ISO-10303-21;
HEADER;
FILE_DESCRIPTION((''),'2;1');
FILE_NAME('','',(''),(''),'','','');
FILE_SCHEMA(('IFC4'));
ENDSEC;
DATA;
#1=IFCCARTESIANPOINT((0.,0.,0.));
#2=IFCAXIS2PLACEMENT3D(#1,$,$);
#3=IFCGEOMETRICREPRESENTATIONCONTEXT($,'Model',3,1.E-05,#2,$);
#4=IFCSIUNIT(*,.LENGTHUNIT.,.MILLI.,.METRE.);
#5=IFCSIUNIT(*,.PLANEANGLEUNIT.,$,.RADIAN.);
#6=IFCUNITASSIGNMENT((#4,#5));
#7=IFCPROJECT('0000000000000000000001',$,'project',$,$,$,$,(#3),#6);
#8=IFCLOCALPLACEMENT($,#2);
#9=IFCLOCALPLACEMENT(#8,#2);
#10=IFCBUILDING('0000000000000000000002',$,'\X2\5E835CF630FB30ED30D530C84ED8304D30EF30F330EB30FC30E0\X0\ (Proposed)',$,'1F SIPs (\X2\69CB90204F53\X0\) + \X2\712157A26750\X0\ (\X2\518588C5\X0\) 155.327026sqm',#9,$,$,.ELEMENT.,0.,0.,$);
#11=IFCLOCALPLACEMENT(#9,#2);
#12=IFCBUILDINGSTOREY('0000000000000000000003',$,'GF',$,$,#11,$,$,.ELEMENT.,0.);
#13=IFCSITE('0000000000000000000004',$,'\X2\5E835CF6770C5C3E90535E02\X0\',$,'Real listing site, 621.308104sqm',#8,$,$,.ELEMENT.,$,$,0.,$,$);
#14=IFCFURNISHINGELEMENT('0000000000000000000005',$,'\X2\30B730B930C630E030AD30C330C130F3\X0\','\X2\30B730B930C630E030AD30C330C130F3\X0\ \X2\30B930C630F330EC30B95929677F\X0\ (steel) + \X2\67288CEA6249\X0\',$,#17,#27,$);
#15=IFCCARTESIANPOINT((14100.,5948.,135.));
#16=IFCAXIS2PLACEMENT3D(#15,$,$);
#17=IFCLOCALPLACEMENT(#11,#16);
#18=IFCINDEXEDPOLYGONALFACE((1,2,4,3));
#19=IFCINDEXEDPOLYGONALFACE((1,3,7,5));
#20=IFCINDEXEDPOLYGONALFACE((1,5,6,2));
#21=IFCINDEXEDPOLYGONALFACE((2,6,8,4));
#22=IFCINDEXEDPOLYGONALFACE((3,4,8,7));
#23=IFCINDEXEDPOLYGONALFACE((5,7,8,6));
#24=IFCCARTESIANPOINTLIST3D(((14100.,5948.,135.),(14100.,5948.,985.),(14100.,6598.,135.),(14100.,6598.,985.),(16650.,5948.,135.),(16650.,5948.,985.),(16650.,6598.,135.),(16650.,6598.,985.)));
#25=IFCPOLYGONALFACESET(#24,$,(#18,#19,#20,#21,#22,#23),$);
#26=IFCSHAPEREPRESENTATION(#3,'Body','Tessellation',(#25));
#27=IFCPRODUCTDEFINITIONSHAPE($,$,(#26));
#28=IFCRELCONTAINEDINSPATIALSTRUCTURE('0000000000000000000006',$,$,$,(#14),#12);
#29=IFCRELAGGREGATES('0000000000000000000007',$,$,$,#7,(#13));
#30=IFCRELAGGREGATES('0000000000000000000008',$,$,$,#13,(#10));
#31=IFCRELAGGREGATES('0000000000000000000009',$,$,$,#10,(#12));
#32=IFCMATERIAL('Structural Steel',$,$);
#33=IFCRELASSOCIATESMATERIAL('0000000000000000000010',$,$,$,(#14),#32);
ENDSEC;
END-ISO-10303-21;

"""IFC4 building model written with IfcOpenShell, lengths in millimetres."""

from ifc_helpers import new_model, si_unit, frame, frame_2d, origin, place, context, project, spatial, rectangle, extrude, material, element, save


model = new_model("IFC4")

# Units and contexts
model_context = context("Model", 3, precision=1e-05, world=origin())
ifc_project = project(units=[si_unit("LENGTHUNIT", "METRE", prefix="MILLI"), si_unit("PLANEANGLEUNIT", "RADIAN")], contexts=[model_context])

# Site, building, storey
site_placement = place(None, origin())
site = spatial("IfcSite", under=ifc_project, at=site_placement, Name="広島県尾道市", ObjectType="Real listing site, 621.308104sqm", CompositionType="ELEMENT", RefElevation=0.0)
building_placement = place(site_placement, origin())
building = spatial("IfcBuilding", under=site, at=building_placement, Name="広島・ロフト付きワンルーム (Proposed)", ObjectType="1F SIPs (構造体) + 無垢材 (内装) 155.327026sqm", CompositionType="ELEMENT", ElevationOfRefHeight=0.0, ElevationOfTerrain=0.0)
storey_placement = place(building_placement, origin())
storey = spatial("IfcBuildingStorey", under=building, at=storey_placement, Name="GF", CompositionType="ELEMENT", Elevation=0.0)

# Furnishing element
ifc_material_1 = material(Name="Structural Steel")
furnishing_1_placement = place(storey_placement, frame((14100.0, 5948.0, 135.0)))
element("IfcFurnishingElement", 1, at=furnishing_1_placement, inside=storey, material=ifc_material_1, Name="システムキッチン", Description="システムキッチン ステンレス天板 (steel) + 木質扉", context=model_context, shape_type="SweptSolid", body=[
    extrude(rectangle(XDim=2550.0, YDim=650.0, at=frame_2d((1275.0, 325.0))), frame((14100.0, 5948.0, 135.0)), (0.0, 0.0, 1.0), 850.0),
])

save(model, "model.ifc")
